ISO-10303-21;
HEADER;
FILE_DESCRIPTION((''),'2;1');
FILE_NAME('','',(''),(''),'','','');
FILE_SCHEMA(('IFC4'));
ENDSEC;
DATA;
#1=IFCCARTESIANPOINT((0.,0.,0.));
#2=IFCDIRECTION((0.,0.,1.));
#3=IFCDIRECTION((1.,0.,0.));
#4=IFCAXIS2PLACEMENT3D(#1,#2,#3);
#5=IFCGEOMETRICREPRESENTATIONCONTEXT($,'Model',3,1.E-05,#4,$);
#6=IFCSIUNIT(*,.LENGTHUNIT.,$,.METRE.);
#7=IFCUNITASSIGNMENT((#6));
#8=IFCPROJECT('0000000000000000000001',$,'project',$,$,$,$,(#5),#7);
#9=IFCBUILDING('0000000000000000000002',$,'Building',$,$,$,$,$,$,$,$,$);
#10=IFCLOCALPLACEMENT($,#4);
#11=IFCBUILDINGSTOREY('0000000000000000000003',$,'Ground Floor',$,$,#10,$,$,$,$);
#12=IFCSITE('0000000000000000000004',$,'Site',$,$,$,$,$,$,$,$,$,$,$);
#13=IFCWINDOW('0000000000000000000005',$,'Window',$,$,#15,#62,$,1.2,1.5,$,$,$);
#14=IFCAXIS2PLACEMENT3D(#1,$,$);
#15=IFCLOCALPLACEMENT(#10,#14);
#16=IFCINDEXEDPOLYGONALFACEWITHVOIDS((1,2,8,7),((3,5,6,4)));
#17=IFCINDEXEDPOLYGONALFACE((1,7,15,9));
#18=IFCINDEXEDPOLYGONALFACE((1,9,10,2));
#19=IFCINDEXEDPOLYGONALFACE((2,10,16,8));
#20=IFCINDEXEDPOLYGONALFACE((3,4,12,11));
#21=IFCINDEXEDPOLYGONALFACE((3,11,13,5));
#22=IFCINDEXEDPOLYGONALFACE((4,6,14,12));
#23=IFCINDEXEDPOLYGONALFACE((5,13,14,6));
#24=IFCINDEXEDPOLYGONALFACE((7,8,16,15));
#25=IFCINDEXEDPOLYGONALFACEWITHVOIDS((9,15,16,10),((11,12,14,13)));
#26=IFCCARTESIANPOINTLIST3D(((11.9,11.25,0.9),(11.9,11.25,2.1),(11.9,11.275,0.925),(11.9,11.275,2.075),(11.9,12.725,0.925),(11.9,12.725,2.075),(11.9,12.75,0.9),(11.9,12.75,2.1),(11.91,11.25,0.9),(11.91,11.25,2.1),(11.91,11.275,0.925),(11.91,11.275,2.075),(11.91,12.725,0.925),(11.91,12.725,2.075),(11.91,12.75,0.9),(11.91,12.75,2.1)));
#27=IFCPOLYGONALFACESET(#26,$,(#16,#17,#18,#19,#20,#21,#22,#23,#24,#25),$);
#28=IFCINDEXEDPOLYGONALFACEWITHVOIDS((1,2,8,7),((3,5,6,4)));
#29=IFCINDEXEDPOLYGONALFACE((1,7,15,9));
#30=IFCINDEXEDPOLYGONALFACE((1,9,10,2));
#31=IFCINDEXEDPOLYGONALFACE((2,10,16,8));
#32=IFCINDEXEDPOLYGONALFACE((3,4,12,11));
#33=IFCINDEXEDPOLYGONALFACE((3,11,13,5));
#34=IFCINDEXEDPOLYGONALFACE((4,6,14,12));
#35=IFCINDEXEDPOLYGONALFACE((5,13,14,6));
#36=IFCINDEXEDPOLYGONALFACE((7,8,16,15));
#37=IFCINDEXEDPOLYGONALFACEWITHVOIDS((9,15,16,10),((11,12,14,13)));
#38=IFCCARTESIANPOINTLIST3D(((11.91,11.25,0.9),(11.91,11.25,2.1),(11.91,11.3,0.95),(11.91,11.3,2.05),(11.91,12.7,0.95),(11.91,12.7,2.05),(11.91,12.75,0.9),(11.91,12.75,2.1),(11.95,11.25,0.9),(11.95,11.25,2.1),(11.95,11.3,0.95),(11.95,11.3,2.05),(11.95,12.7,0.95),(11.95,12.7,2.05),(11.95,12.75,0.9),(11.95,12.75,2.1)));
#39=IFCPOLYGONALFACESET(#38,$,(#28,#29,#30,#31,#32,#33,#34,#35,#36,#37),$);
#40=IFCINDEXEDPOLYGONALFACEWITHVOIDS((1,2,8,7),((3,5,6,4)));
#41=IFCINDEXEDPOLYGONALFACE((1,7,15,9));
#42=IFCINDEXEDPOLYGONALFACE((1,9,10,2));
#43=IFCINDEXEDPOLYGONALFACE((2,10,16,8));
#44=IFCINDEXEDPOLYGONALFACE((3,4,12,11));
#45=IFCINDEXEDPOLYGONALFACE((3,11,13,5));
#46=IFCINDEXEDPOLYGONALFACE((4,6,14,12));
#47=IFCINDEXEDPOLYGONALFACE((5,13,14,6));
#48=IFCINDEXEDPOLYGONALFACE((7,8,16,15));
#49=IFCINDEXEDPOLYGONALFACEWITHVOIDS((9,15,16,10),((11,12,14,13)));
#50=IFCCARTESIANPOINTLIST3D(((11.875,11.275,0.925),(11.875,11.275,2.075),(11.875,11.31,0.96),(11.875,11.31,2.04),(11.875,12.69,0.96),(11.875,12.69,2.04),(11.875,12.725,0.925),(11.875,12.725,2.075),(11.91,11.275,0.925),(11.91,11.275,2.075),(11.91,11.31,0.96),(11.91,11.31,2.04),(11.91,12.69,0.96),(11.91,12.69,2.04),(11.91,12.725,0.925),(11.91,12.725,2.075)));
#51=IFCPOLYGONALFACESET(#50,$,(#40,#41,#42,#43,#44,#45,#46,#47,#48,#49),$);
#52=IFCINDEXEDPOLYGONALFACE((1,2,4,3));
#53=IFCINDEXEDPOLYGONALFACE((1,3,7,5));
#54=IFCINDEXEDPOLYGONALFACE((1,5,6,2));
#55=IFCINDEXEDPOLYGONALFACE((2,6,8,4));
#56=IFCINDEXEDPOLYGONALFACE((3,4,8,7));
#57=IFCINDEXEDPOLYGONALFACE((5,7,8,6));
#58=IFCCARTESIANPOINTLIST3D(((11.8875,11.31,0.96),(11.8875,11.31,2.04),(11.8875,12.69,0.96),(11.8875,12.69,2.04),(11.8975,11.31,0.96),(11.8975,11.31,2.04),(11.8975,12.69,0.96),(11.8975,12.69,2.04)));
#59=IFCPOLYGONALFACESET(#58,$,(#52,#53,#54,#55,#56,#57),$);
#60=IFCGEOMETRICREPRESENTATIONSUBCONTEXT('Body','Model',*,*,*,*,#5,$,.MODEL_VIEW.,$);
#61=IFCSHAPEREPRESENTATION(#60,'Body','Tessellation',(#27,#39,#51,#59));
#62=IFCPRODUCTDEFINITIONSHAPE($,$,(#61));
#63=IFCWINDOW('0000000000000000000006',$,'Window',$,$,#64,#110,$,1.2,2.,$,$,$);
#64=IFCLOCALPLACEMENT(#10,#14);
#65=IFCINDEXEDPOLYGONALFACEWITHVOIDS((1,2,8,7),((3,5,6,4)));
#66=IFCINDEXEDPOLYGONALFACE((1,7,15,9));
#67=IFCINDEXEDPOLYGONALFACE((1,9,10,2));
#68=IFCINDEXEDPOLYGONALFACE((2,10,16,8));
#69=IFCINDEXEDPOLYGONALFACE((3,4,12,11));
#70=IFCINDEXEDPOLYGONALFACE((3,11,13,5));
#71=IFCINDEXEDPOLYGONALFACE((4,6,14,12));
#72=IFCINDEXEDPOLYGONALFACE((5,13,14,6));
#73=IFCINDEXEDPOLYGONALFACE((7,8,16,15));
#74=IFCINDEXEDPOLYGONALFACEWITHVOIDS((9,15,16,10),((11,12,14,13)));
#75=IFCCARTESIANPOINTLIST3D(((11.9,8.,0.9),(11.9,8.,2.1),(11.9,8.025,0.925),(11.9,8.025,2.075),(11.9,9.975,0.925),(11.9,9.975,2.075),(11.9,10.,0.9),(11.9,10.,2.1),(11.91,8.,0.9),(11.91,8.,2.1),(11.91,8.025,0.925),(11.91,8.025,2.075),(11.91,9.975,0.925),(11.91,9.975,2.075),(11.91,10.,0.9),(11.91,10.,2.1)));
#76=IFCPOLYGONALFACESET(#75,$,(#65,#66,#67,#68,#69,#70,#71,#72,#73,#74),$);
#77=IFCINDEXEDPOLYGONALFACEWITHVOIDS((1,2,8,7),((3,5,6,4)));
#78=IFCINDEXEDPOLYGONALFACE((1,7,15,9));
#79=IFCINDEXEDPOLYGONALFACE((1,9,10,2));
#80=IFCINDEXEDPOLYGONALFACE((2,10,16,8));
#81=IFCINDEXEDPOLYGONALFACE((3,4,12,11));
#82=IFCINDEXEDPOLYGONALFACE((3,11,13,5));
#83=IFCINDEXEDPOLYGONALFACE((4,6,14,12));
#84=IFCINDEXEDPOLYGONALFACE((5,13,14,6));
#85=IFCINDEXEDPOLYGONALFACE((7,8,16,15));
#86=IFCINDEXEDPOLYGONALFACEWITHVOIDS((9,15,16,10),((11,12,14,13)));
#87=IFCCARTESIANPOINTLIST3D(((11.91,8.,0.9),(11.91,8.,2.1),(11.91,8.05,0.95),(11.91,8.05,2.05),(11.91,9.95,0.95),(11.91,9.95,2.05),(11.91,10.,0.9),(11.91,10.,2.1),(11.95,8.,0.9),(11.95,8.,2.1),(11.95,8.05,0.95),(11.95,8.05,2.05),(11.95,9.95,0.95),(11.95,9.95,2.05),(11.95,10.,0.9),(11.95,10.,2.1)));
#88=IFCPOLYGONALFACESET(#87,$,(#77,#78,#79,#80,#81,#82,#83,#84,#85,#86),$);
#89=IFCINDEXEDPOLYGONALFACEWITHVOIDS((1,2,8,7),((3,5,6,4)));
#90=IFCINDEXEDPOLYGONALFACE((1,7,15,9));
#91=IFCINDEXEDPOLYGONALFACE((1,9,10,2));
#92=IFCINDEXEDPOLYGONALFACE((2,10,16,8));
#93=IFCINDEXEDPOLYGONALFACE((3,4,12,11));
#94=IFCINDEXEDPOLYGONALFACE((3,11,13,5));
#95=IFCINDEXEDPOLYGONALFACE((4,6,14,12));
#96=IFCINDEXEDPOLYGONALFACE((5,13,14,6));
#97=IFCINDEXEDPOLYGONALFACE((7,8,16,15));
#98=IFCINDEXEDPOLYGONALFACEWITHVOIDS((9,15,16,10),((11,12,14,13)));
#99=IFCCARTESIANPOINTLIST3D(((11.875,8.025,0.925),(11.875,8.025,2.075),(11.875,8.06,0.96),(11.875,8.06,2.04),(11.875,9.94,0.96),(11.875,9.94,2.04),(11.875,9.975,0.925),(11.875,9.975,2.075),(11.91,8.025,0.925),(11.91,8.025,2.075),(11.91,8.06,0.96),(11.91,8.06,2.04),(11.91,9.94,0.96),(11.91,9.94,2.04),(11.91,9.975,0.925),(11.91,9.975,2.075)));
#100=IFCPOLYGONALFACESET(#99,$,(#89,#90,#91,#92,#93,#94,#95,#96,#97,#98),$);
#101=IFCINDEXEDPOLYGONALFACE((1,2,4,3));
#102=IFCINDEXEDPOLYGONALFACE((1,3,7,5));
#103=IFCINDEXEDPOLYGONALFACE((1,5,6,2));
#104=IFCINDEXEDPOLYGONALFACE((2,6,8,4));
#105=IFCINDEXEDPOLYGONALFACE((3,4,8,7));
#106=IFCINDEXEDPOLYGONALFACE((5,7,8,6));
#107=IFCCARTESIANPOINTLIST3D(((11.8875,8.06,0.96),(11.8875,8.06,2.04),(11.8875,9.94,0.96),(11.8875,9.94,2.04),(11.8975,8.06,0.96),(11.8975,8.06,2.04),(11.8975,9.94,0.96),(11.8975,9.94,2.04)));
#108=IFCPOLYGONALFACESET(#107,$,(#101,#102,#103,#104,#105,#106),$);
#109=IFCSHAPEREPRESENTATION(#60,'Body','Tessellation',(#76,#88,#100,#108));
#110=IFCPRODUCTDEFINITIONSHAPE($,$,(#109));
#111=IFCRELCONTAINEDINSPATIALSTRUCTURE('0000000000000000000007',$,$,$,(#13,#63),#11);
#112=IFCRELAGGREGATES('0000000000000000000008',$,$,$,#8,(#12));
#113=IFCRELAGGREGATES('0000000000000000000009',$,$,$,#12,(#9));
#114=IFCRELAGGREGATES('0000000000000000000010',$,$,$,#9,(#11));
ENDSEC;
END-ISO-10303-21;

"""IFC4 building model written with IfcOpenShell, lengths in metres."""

from ifc_helpers import new_model, si_unit, frame, origin_with_axes, place, context, subcontext, project, spatial, line, indexed_curve, outline, extrude, element, save


model = new_model("IFC4")

# Units and contexts
model_context = context("Model", 3, precision=1e-05, world=origin_with_axes())
body_context = subcontext(model_context, "Body", "Model", "MODEL_VIEW")
ifc_project = project(units=[si_unit("LENGTHUNIT", "METRE")], contexts=[model_context])

# Site, building, storey
site = spatial("IfcSite", under=ifc_project, Name="Site")
building = spatial("IfcBuilding", under=site, Name="Building")
storey_placement = place(None, origin_with_axes())
storey = spatial("IfcBuildingStorey", under=building, at=storey_placement, Name="Ground Floor")

# Windows
window_1_placement = place(storey_placement, frame((12.0, 11.25, 0.9), z_axis=(0.0, 0.0, 1.0), x_axis=(0.0, 1.0, 0.0)))
element("IfcWindow", 1, at=window_1_placement, inside=storey, Name="Window", OverallHeight=1.2, OverallWidth=1.5, context=body_context, shape_type="SweptSolid", body=[
    extrude(outline(indexed_curve([(0.0, 0.0), (1.5, 0.0), (1.5, 1.2), (0.0, 1.2)], segments=[line(1, 2, 3, 4, 1)]), holes=[indexed_curve([(0.025, 0.025), (1.475, 0.025), (1.475, 1.175), (0.025, 1.175)], segments=[line(1, 2, 3, 4, 1)])]), frame((0.0, 0.09, 0.0), z_axis=(0.0, -1.0, 0.0), x_axis=(1.0, 0.0, 0.0)), (0.0, 0.0, -1.0), 0.01),
    extrude(outline(indexed_curve([(0.0, 0.0), (1.5, 0.0), (1.5, 1.2), (0.0, 1.2)], segments=[line(1, 2, 3, 4, 1)]), holes=[indexed_curve([(0.05, 0.05), (1.45, 0.05), (1.45, 1.15), (0.05, 1.15)], segments=[line(1, 2, 3, 4, 1)])]), frame((0.0, 0.05, 0.0), z_axis=(0.0, -1.0, 0.0), x_axis=(1.0, 0.0, 0.0)), (0.0, 0.0, -1.0), 0.04),
    extrude(outline(indexed_curve([(0.0, 0.0), (1.45, 0.0), (1.45, 1.15), (0.0, 1.15)], segments=[line(1, 2, 3, 4, 1)]), holes=[indexed_curve([(0.035, 0.035), (1.415, 0.035), (1.415, 1.115), (0.035, 1.115)], segments=[line(1, 2, 3, 4, 1)])]), frame((0.025, 0.09, 0.025), z_axis=(0.0, -1.0, 0.0), x_axis=(1.0, 0.0, 0.0)), (0.0, 0.0, -1.0), 0.035),
    extrude(outline(indexed_curve([(0.035, 0.035), (1.415, 0.035), (1.415, 1.115), (0.035, 1.115)], segments=[line(1, 2, 3, 4, 1)])), frame((0.025, 0.1025, 0.025), z_axis=(0.0, -1.0, 0.0), x_axis=(1.0, 0.0, 0.0)), (0.0, 0.0, -1.0), 0.01),
])
window_2_placement = place(storey_placement, frame((12.0, 8.0, 0.9), z_axis=(0.0, 0.0, 1.0), x_axis=(0.0, 1.0, 0.0)))
element("IfcWindow", 2, at=window_2_placement, inside=storey, Name="Window", OverallHeight=1.2, OverallWidth=2.0, context=body_context, shape_type="SweptSolid", body=[
    extrude(outline(indexed_curve([(0.0, 0.0), (2.0, 0.0), (2.0, 1.2), (0.0, 1.2)], segments=[line(1, 2, 3, 4, 1)]), holes=[indexed_curve([(0.025, 0.025), (1.975, 0.025), (1.975, 1.175), (0.025, 1.175)], segments=[line(1, 2, 3, 4, 1)])]), frame((0.0, 0.09, 0.0), z_axis=(0.0, -1.0, 0.0), x_axis=(1.0, 0.0, 0.0)), (0.0, 0.0, -1.0), 0.01),
    extrude(outline(indexed_curve([(0.0, 0.0), (2.0, 0.0), (2.0, 1.2), (0.0, 1.2)], segments=[line(1, 2, 3, 4, 1)]), holes=[indexed_curve([(0.05, 0.05), (1.95, 0.05), (1.95, 1.15), (0.05, 1.15)], segments=[line(1, 2, 3, 4, 1)])]), frame((0.0, 0.05, 0.0), z_axis=(0.0, -1.0, 0.0), x_axis=(1.0, 0.0, 0.0)), (0.0, 0.0, -1.0), 0.04),
    extrude(outline(indexed_curve([(0.0, 0.0), (1.95, 0.0), (1.95, 1.15), (0.0, 1.15)], segments=[line(1, 2, 3, 4, 1)]), holes=[indexed_curve([(0.035, 0.035), (1.915, 0.035), (1.915, 1.115), (0.035, 1.115)], segments=[line(1, 2, 3, 4, 1)])]), frame((0.025, 0.09, 0.025), z_axis=(0.0, -1.0, 0.0), x_axis=(1.0, 0.0, 0.0)), (0.0, 0.0, -1.0), 0.035),
    extrude(outline(indexed_curve([(0.035, 0.035), (1.915, 0.035), (1.915, 1.115), (0.035, 1.115)], segments=[line(1, 2, 3, 4, 1)])), frame((0.025, 0.1025, 0.025), z_axis=(0.0, -1.0, 0.0), x_axis=(1.0, 0.0, 0.0)), (0.0, 0.0, -1.0), 0.01),
])

save(model, "model.ifc")
